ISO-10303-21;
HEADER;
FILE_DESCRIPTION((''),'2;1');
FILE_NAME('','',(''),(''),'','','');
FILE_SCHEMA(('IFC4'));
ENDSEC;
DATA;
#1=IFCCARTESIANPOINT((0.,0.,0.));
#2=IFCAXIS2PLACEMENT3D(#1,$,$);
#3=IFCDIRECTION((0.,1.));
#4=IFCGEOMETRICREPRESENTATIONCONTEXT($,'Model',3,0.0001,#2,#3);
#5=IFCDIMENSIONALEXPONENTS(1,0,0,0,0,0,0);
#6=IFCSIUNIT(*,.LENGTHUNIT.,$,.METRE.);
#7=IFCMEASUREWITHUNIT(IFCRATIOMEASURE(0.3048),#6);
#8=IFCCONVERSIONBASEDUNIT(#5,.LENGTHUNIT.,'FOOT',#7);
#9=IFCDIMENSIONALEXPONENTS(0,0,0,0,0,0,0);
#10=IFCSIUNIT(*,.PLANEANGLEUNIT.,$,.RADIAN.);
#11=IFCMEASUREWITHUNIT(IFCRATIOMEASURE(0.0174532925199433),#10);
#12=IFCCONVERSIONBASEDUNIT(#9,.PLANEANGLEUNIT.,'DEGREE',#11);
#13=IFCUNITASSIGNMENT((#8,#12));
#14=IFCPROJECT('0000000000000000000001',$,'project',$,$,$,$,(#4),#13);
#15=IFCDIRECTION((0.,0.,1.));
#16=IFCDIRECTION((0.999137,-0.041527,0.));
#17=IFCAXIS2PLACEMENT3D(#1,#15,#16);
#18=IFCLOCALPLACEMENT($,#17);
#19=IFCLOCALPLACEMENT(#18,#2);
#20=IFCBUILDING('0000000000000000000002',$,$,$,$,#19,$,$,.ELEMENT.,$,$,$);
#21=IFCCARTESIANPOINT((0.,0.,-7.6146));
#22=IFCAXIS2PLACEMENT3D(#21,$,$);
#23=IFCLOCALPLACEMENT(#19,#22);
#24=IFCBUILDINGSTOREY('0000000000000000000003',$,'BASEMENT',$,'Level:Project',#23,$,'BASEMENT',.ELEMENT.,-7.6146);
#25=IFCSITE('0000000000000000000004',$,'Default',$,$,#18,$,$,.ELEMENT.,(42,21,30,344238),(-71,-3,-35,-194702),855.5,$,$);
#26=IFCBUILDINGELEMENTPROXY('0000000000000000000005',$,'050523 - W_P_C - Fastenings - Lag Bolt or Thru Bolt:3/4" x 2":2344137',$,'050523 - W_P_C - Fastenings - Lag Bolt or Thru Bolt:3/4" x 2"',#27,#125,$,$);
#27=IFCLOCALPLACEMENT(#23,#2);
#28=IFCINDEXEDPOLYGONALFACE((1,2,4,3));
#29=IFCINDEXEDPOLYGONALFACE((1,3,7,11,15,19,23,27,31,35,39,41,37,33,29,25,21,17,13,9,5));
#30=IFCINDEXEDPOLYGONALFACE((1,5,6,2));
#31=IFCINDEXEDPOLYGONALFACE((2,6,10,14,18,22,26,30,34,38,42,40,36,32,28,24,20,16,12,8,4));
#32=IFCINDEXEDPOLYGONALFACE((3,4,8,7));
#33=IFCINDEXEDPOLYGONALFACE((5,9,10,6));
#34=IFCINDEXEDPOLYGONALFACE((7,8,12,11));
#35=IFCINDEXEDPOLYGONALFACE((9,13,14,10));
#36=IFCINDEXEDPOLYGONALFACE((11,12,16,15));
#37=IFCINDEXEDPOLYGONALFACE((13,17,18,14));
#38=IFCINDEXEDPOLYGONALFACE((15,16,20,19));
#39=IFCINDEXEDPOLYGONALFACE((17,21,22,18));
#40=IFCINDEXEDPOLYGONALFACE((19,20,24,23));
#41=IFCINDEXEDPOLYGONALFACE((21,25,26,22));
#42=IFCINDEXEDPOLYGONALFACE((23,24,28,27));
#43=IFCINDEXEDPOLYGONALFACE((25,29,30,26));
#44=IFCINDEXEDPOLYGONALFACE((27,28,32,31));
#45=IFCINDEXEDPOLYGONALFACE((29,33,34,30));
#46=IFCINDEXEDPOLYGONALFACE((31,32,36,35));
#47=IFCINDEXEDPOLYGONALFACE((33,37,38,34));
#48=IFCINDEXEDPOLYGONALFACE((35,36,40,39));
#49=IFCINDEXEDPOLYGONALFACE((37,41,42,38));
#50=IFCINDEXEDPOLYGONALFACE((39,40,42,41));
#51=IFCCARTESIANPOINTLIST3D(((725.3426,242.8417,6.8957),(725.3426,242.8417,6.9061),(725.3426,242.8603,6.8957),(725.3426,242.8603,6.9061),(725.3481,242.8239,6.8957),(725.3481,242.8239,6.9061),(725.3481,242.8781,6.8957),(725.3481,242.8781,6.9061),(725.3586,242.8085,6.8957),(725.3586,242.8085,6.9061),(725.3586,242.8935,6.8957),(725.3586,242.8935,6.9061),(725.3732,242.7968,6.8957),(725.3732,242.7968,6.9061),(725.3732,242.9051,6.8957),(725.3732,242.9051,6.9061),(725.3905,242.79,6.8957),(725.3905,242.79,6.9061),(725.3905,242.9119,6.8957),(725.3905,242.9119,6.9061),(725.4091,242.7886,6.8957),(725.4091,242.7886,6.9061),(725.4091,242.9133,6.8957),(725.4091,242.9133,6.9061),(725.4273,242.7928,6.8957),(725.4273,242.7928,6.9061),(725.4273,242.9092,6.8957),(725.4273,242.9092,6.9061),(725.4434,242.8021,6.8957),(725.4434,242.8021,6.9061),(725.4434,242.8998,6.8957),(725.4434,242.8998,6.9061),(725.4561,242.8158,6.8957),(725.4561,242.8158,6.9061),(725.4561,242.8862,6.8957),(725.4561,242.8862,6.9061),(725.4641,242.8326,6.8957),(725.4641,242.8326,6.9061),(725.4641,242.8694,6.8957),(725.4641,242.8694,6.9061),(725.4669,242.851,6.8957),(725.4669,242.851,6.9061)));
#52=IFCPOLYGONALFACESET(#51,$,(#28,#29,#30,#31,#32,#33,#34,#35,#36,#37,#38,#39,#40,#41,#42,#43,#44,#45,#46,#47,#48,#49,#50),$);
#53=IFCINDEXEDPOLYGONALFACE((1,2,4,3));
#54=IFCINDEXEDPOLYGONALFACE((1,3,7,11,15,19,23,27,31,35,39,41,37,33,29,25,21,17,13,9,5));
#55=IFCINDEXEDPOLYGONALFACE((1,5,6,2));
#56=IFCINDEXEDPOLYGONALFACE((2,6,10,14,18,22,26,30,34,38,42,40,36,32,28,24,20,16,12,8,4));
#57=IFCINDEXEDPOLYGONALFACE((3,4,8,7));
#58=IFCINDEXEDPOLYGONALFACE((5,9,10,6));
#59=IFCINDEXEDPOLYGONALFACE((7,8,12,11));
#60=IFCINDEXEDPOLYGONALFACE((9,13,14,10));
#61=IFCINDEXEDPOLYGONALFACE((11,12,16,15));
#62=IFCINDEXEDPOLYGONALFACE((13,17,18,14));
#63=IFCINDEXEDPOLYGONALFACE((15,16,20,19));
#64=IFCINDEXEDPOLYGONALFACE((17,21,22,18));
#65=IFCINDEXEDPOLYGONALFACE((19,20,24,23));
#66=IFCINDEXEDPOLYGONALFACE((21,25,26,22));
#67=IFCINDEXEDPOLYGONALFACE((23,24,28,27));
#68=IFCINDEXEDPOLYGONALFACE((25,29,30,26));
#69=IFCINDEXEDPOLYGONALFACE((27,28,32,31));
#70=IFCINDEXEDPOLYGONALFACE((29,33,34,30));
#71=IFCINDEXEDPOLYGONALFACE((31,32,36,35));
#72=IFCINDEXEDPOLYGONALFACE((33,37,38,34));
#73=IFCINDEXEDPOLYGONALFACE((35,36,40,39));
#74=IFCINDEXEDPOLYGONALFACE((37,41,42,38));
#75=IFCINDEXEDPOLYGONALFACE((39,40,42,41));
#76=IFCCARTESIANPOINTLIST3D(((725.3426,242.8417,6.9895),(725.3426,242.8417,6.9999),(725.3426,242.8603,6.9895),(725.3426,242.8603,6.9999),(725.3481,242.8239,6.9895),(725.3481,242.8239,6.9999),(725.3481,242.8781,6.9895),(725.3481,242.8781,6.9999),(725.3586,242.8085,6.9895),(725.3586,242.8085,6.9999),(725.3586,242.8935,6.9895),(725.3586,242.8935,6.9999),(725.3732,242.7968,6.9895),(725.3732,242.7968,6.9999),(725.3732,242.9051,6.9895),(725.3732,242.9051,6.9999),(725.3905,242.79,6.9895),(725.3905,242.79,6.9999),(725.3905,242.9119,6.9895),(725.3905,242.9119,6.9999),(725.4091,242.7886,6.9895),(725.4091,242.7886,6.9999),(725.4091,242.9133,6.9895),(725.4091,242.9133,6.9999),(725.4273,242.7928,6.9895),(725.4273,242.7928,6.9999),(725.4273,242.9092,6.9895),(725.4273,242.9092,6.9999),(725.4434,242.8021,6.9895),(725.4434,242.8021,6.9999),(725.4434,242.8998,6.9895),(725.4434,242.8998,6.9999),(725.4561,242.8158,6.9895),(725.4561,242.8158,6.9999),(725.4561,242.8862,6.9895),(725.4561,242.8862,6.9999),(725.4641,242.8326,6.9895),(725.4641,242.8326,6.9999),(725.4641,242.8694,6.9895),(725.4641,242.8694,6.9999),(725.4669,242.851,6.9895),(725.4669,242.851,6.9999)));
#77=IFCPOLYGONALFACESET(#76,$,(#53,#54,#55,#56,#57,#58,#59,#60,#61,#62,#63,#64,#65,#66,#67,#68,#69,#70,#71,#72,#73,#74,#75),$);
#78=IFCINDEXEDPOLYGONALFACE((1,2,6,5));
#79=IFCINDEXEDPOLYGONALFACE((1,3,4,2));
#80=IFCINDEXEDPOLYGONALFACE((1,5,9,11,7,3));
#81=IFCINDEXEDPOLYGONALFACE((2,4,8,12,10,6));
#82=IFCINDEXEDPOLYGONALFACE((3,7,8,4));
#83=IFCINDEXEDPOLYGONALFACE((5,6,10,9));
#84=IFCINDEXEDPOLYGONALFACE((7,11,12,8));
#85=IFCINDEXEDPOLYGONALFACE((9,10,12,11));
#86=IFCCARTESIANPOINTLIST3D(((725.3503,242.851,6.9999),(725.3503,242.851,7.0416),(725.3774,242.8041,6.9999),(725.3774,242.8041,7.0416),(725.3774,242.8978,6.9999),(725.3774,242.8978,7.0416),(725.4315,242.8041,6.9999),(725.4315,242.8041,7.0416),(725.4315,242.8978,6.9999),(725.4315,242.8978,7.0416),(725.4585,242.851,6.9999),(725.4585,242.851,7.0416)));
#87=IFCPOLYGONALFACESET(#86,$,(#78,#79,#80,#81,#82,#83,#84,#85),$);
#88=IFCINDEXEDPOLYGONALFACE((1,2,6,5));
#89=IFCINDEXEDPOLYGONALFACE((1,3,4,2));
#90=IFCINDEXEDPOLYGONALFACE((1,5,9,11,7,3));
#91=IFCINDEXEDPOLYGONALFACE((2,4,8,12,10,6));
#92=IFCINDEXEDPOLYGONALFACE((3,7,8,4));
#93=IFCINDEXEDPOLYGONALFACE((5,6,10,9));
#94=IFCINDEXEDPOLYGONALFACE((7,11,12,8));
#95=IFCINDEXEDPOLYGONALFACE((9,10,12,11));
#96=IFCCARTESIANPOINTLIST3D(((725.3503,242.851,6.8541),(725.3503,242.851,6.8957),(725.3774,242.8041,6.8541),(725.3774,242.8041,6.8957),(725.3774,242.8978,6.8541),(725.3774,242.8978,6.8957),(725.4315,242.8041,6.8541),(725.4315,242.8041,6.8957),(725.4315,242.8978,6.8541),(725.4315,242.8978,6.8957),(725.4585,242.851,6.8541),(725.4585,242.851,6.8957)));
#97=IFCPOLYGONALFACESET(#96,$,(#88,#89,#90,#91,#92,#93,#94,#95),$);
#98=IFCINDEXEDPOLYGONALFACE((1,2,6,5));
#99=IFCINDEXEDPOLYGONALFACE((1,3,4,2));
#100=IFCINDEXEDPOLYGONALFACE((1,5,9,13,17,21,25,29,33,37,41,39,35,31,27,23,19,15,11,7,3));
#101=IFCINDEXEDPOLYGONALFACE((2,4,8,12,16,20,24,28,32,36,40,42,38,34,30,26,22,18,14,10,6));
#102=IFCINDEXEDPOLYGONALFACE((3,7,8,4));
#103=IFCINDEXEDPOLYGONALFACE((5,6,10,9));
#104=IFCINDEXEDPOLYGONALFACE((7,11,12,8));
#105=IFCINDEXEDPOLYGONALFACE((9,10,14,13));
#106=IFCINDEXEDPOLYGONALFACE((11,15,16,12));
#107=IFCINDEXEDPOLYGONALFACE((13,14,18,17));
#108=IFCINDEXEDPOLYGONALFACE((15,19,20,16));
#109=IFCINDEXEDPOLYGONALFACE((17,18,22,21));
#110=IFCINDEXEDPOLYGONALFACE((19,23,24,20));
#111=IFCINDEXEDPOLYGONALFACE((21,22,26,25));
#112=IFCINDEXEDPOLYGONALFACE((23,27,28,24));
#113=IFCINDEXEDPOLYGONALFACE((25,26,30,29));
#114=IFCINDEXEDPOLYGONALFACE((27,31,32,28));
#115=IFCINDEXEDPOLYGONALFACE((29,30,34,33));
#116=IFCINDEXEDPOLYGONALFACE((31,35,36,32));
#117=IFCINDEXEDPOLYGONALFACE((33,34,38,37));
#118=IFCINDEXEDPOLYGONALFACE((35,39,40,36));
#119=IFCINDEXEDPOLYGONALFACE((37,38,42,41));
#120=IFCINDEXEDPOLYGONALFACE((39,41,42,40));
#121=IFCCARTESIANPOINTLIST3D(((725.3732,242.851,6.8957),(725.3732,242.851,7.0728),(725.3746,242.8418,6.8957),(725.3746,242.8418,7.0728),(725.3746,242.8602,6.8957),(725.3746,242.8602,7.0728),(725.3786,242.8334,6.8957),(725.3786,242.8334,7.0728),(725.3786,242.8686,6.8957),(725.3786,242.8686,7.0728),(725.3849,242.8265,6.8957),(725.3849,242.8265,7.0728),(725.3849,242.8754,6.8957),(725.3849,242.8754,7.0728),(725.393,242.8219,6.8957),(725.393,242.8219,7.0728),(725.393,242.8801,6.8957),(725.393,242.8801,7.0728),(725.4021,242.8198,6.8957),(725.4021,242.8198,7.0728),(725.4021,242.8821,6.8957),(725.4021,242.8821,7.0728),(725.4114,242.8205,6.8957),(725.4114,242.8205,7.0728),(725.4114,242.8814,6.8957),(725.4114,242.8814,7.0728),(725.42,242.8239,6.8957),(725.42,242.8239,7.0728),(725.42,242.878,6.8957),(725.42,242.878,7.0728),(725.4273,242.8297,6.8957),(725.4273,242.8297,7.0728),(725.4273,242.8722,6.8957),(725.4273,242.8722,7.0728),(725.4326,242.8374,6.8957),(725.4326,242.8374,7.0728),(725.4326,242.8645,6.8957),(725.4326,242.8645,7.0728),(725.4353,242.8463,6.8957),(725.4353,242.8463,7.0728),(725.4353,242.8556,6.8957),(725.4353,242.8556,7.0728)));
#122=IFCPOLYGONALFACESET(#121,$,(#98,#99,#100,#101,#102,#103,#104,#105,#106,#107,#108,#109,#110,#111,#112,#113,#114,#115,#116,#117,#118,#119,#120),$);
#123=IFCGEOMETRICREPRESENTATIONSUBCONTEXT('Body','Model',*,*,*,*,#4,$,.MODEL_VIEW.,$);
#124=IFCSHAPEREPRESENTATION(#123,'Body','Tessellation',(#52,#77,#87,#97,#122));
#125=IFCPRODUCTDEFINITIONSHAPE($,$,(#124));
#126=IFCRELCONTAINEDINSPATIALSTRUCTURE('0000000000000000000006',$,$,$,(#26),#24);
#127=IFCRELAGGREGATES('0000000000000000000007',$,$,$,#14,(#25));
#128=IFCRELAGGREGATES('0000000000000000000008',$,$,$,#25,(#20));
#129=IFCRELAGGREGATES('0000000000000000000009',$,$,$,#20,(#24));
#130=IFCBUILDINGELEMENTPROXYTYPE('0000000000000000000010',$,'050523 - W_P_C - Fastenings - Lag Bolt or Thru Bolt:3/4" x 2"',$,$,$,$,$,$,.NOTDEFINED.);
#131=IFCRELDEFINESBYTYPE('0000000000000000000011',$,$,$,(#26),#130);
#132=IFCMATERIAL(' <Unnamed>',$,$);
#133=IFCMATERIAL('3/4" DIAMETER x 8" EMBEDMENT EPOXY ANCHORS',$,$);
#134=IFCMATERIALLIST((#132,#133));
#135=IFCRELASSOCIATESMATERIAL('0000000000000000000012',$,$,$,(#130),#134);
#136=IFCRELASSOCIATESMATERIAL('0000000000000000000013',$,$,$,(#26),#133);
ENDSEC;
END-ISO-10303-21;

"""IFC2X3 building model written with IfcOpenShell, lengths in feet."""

from ifc_helpers import new_model, entity, si_unit, converted_unit, direction, frame, frame_2d, origin, place, context, subcontext, project, spatial, polyline, circle, outline, extrude, source, transform, mapped, material, material_list, type_object, type_shapes, element, save


model = new_model("IFC2X3")

# Units and contexts
model_context = context("Model", 3, precision=0.0001, world=origin(), true_north=direction((0.0, 1.0)))
body_context = subcontext(model_context, "Body", "Model", "MODEL_VIEW")
ifc_project = project(units=[converted_unit("LENGTHUNIT", "FOOT", entity("IfcRatioMeasure", 0.3048), si_unit("LENGTHUNIT", "METRE"), dimensions=[1, 0, 0, 0, 0, 0, 0]), converted_unit("PLANEANGLEUNIT", "DEGREE", entity("IfcRatioMeasure", 0.0174532925199433), si_unit("PLANEANGLEUNIT", "RADIAN"), dimensions=[0, 0, 0, 0, 0, 0, 0])], contexts=[model_context])

# Site, building, storey
site_placement = place(None, frame((0.0, 0.0, 0.0), z_axis=(0.0, 0.0, 1.0), x_axis=(0.999137, -0.041527, 0.0)))
site = spatial("IfcSite", under=ifc_project, at=site_placement, Name="Default", CompositionType="ELEMENT", RefLatitude=(42, 21, 30, 344238), RefLongitude=(-71, -3, -35, -194702), RefElevation=855.5)
building_placement = place(site_placement, origin())
building = spatial("IfcBuilding", under=site, at=building_placement, CompositionType="ELEMENT")
storey_placement = place(building_placement, frame((0.0, 0.0, -7.6146)))
storey = spatial("IfcBuildingStorey", under=building, at=storey_placement, Name="BASEMENT", ObjectType="Level:Project", LongName="BASEMENT", CompositionType="ELEMENT", Elevation=-7.6146)

# Building element proxy
ifc_material_1 = material(Name="3/4\" DIAMETER x 8\" EMBEDMENT EPOXY ANCHORS")
ifc_material_2 = material(Name=" <Unnamed>")
ifc_material_list_1 = material_list([ifc_material_2, ifc_material_1])
building_element_proxy_type_1 = type_object("IfcBuildingElementProxyType", Name="050523 - W_P_C - Fastenings - Lag Bolt or Thru Bolt:3/4\" x 2\"", PredefinedType="NOTDEFINED", material=ifc_material_list_1)
shared_shape_1 = source(origin(), body_context, "Body", "SweptSolid", [
    extrude(circle(Radius=0.0625, at=frame_2d((0.0, 0.0), x_axis=(1.0, 0.0))), frame((0.0, 0.0, 0.0), z_axis=(0.0, 0.0, 1.0), x_axis=(0.0, -1.0, 0.0)), (0.0, 0.0, 1.0), 0.0104),
    extrude(circle(Radius=0.0625, at=frame_2d((0.0, 0.0), x_axis=(1.0, 0.0))), frame((0.0, 0.0, -0.0938), z_axis=(0.0, 0.0, 1.0), x_axis=(0.0, -1.0, 0.0)), (0.0, 0.0, 1.0), 0.0104),
    extrude(outline(polyline([(-0.0271, -0.0469), (0.0271, -0.0469), (0.0541, 0.0), (0.0271, 0.0469), (-0.0271, 0.0469), (-0.0541, 0.0), (-0.0271, -0.0469)])), frame((0.0, 0.0, -0.1354), z_axis=(0.0, 0.0, 1.0), x_axis=(0.866025, -0.5, 0.0)), (0.0, 0.0, 1.0), 0.0417),
    extrude(outline(polyline([(-0.0271, -0.0469), (0.0271, -0.0469), (0.0541, 0.0), (0.0271, 0.0469), (-0.0271, 0.0469), (-0.0541, 0.0), (-0.0271, -0.0469)])), frame((0.0, 0.0, 0.0104), z_axis=(0.0, 0.0, 1.0), x_axis=(0.0, -1.0, 0.0)), (0.0, 0.0, 1.0), 0.0417),
    extrude(circle(Radius=0.0312, at=frame_2d((0.0, 0.0), x_axis=(1.0, 0.0))), frame((0.0, 0.0, -0.1667), z_axis=(0.0, 0.0, 1.0), x_axis=(0.0, 1.0, 0.0)), (0.0, 0.0, 1.0), 0.1771),
])
type_shapes(building_element_proxy_type_1, [shared_shape_1])
for number, where, z_axis, x_axis, name in (
    (1, (725.4044, 242.851, 6.9061), (0.0, 0.0, -1.0), (0.0, -1.0, 0.0), "050523 - W_P_C - Fastenings - Lag Bolt or Thru Bolt:3/4\" x 2\":2344137"),
):
    element("IfcBuildingElementProxy", number, at=place(storey_placement, frame(where, z_axis=z_axis, x_axis=x_axis)), inside=storey, type_object=building_element_proxy_type_1, material=ifc_material_1, Name=name, ObjectType="050523 - W_P_C - Fastenings - Lag Bolt or Thru Bolt:3/4\" x 2\"", context=body_context, shape_type="MappedRepresentation", body=[
        mapped(shared_shape_1, transform((0.0, 0.0, 0.0), scale=1.0)),
    ])

save(model, "model.ifc")
